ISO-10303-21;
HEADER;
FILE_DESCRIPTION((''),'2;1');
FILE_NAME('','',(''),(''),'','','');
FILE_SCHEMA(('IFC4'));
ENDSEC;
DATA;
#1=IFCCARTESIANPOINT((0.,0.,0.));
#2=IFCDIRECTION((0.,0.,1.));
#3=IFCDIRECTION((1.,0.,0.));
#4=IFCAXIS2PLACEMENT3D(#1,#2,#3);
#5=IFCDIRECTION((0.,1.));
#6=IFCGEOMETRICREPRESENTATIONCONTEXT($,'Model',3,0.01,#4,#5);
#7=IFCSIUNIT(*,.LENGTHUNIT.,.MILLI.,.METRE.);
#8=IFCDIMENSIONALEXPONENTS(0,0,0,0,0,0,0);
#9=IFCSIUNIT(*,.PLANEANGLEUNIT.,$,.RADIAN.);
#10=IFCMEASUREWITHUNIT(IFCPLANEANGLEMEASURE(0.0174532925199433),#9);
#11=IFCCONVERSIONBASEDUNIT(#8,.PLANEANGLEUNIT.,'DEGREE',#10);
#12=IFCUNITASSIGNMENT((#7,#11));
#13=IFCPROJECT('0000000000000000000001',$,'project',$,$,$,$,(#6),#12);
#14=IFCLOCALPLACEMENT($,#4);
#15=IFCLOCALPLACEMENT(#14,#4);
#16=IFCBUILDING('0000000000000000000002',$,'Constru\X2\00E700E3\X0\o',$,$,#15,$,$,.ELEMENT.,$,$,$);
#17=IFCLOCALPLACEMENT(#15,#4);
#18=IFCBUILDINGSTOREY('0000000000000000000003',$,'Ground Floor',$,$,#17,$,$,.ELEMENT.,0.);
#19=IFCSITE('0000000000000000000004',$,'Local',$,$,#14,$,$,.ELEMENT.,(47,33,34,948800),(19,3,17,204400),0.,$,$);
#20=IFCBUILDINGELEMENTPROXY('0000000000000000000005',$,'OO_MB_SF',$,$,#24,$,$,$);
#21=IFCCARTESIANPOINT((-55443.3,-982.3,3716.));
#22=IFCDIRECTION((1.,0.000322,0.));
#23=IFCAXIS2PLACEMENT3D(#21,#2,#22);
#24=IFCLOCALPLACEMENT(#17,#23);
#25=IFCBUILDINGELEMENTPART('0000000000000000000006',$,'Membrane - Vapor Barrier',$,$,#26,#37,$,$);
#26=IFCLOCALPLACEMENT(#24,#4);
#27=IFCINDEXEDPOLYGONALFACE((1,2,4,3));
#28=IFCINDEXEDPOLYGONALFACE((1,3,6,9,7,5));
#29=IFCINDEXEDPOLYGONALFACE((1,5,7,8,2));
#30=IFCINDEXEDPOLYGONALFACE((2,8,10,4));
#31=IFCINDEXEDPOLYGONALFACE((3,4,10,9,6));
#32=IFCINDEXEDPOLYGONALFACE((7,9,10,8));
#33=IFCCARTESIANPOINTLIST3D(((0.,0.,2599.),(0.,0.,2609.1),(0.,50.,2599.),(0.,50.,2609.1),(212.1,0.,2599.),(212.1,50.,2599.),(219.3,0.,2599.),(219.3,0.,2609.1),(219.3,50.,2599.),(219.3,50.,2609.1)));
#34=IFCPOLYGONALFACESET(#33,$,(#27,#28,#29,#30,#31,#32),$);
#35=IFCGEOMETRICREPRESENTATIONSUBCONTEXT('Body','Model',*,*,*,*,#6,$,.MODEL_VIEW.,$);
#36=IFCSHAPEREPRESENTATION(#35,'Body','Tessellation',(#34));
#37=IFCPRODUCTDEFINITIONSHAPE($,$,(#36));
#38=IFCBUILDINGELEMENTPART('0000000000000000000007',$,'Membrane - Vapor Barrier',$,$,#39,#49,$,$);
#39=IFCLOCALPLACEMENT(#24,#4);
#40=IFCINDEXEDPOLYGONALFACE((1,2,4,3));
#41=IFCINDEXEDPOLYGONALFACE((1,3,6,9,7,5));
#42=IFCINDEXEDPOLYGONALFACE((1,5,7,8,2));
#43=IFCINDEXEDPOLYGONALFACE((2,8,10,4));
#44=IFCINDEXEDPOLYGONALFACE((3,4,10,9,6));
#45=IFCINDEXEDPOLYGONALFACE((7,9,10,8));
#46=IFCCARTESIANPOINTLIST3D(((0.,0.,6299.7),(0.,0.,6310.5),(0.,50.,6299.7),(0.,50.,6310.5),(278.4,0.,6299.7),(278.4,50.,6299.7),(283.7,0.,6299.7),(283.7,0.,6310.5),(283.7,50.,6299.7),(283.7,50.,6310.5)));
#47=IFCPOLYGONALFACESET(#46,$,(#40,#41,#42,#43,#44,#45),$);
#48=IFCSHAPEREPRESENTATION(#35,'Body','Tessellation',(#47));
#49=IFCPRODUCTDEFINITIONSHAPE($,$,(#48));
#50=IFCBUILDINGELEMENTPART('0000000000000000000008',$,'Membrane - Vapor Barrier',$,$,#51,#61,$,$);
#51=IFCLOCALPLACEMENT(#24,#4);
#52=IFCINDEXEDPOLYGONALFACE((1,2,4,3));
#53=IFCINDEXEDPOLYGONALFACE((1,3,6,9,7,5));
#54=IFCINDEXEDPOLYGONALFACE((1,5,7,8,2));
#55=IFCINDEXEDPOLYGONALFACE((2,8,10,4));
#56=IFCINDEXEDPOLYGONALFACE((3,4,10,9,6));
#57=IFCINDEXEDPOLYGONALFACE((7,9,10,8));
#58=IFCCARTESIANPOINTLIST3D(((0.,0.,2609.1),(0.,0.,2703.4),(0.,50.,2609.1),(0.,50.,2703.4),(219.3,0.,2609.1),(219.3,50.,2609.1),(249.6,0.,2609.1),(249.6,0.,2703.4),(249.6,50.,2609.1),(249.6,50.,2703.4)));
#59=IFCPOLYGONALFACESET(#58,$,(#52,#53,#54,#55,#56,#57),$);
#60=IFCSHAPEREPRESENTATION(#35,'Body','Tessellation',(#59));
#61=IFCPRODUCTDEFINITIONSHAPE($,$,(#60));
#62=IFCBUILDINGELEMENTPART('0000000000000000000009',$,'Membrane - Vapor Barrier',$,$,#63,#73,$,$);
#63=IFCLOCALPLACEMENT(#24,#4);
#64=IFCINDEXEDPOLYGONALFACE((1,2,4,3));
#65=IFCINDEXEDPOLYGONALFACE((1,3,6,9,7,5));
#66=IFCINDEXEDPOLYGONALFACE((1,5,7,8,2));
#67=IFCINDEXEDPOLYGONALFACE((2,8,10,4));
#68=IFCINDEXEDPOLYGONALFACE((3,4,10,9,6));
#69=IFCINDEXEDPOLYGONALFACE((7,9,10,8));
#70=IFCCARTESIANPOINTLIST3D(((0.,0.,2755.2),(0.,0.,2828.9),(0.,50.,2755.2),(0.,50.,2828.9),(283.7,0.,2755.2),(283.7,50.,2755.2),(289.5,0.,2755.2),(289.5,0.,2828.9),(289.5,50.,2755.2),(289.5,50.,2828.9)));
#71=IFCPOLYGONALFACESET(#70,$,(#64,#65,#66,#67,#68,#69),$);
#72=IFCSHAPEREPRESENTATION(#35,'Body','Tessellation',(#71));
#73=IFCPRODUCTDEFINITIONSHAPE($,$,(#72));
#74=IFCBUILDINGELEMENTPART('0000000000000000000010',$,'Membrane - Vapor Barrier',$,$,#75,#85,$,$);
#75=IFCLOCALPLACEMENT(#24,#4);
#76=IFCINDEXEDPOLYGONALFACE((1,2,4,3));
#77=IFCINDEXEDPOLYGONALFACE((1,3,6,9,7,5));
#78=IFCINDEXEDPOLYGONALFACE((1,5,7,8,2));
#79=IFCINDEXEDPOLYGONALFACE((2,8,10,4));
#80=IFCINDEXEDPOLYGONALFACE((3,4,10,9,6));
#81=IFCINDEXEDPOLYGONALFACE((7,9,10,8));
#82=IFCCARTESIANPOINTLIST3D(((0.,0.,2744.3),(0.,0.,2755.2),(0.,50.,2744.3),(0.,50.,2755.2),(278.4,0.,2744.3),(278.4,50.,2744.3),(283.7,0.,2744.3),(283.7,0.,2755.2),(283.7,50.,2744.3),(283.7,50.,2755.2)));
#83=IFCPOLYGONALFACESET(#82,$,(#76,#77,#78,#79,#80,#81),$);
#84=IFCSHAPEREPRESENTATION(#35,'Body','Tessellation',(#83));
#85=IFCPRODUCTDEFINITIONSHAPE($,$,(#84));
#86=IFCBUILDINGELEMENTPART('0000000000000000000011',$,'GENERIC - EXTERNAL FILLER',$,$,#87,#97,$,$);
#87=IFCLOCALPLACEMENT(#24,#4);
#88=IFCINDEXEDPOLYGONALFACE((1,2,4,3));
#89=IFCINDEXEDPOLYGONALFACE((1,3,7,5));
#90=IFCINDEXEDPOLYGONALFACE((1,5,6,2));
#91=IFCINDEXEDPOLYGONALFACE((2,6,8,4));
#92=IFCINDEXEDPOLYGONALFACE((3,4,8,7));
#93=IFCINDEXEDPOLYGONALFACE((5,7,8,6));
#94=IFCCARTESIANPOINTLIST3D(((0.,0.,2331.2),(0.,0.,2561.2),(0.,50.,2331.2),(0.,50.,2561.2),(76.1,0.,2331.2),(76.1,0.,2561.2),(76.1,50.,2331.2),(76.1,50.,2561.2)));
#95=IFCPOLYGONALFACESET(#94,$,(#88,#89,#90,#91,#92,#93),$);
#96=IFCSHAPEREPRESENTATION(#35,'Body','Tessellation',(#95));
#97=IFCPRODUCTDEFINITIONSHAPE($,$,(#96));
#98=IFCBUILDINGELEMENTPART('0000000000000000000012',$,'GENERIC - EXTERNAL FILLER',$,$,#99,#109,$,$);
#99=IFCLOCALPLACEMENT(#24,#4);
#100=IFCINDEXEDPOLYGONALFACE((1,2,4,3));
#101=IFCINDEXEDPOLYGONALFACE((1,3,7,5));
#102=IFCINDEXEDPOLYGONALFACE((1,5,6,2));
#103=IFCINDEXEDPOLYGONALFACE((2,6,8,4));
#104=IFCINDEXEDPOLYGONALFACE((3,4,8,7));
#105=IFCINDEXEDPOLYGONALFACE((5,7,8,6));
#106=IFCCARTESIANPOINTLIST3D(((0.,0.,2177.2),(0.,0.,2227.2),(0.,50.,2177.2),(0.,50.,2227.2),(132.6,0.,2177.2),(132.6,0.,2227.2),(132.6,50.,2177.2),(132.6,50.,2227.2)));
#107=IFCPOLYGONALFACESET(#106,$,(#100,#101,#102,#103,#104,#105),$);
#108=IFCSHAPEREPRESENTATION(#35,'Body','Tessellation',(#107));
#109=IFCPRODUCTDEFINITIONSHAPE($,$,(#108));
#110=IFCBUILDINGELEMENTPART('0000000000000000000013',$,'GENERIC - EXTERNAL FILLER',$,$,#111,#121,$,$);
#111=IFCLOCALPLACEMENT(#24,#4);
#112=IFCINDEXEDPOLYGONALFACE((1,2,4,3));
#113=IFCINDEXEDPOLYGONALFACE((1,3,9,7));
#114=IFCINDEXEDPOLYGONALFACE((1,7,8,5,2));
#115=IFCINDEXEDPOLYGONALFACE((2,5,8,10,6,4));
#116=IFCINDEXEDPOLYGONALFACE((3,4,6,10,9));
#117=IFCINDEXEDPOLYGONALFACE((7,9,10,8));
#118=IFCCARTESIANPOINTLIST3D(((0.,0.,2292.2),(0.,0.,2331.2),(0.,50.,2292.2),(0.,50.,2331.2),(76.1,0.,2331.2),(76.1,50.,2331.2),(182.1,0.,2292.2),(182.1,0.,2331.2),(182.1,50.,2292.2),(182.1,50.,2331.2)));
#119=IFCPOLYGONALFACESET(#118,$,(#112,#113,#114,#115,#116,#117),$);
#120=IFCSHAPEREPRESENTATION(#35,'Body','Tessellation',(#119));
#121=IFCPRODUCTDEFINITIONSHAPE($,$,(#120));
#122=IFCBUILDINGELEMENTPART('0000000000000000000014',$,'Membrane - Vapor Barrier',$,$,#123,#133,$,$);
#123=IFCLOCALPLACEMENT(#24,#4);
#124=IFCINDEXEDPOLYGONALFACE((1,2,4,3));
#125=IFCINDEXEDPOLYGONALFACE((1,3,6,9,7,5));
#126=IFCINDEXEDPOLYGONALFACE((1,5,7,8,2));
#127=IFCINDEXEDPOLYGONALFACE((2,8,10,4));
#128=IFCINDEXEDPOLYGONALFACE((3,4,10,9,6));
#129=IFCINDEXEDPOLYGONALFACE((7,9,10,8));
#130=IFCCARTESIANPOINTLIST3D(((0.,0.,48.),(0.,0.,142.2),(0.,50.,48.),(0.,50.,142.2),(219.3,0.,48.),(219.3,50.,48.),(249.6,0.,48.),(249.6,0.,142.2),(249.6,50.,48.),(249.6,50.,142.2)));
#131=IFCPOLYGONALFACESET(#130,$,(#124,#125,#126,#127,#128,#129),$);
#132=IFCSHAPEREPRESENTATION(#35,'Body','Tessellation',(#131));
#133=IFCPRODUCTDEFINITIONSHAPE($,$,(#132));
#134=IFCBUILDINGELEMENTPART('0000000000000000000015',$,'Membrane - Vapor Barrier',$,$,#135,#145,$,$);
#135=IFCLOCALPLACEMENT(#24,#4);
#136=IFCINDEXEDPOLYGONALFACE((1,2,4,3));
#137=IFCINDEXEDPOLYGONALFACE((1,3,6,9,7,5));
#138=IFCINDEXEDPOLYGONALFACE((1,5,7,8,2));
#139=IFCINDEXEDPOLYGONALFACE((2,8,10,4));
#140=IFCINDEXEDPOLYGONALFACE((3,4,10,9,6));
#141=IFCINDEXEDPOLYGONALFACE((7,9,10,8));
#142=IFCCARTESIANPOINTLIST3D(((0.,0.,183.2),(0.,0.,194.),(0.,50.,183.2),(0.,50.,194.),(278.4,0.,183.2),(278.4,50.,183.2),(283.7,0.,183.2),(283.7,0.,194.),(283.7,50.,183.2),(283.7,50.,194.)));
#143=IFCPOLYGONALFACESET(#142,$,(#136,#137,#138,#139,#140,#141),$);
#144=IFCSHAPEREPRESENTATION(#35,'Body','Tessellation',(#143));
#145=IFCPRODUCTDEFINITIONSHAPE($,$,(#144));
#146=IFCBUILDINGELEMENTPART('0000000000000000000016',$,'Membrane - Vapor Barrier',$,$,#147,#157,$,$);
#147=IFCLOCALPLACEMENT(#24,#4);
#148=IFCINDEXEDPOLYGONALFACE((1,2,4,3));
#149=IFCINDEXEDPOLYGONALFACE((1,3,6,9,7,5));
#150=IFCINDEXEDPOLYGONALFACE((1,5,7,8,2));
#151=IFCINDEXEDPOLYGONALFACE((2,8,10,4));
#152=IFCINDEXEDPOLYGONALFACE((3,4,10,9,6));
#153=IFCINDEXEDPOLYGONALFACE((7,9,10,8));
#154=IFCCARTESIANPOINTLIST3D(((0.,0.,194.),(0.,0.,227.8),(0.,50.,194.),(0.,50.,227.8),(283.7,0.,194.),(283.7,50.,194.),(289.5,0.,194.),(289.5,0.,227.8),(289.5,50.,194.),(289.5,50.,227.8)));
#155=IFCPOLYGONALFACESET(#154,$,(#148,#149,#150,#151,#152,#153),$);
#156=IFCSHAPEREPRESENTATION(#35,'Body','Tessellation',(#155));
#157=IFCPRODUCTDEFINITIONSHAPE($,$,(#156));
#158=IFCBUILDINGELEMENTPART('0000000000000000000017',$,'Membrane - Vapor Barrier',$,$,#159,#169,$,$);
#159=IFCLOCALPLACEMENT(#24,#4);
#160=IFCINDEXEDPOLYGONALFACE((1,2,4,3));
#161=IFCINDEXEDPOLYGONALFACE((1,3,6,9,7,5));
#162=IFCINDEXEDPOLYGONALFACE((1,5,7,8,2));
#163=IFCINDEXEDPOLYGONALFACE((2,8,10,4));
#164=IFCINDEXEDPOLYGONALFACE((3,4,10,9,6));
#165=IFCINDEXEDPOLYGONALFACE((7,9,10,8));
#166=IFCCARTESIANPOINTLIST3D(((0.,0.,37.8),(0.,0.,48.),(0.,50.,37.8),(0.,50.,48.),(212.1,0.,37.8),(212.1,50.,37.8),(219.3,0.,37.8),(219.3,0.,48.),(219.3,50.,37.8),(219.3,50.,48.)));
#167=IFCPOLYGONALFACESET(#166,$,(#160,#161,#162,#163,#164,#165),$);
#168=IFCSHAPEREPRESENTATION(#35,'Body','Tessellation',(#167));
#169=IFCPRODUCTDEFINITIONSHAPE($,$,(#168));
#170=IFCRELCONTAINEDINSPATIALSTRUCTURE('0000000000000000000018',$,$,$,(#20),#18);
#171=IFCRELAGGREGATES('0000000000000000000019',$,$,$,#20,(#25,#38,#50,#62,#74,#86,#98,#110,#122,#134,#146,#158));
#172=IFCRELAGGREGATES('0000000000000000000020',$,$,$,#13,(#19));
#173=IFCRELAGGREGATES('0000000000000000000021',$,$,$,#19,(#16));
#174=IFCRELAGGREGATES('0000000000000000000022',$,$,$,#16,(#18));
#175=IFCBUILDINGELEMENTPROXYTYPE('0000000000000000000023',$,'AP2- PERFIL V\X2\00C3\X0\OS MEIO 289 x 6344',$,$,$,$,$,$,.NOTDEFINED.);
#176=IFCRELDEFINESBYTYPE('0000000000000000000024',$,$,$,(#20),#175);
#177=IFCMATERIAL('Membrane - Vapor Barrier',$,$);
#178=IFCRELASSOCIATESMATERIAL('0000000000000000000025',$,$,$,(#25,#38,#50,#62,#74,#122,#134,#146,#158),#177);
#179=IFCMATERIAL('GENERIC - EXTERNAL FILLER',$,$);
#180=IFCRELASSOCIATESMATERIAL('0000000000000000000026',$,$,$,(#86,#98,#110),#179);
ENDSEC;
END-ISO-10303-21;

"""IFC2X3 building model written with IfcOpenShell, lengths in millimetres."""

from ifc_helpers import new_model, entity, si_unit, converted_unit, direction, frame, origin_with_axes, place, context, subcontext, project, spatial, polyline, outline, extrude, material, type_object, element, aggregate, save


model = new_model("IFC2X3")

# Units and contexts
model_context = context("Model", 3, precision=0.01, world=origin_with_axes(), true_north=direction((0.0, 1.0)))
body_context = subcontext(model_context, "Body", "Model", "MODEL_VIEW")
ifc_project = project(units=[si_unit("LENGTHUNIT", "METRE", prefix="MILLI"), converted_unit("PLANEANGLEUNIT", "DEGREE", entity("IfcPlaneAngleMeasure", 0.0174532925199433), si_unit("PLANEANGLEUNIT", "RADIAN"), dimensions=[0, 0, 0, 0, 0, 0, 0])], contexts=[model_context])

# Site, building, storey
site_placement = place(None, origin_with_axes())
site = spatial("IfcSite", under=ifc_project, at=site_placement, Name="Local", CompositionType="ELEMENT", RefLatitude=(47, 33, 34, 948800), RefLongitude=(19, 3, 17, 204400), RefElevation=0.0)
building_placement = place(site_placement, origin_with_axes())
building = spatial("IfcBuilding", under=site, at=building_placement, Name="Construção", CompositionType="ELEMENT")
storey_placement = place(building_placement, origin_with_axes())
storey = spatial("IfcBuildingStorey", under=building, at=storey_placement, Name="Ground Floor", CompositionType="ELEMENT", Elevation=0.0)

# Building element proxy, building element parts
building_element_proxy_type = type_object("IfcBuildingElementProxyType", Name="AP2- PERFIL VÃOS MEIO 289 x 6344", PredefinedType="NOTDEFINED")
ifc_material_1 = material(Name="Membrane - Vapor Barrier")
ifc_material_2 = material(Name="GENERIC - EXTERNAL FILLER")
proxy_1_placement = place(storey_placement, frame((-55443.3, -982.3, 3716.0), z_axis=(0.0, 0.0, 1.0), x_axis=(1.0, 0.000322, 0.0)))
proxy_1 = element("IfcBuildingElementProxy", 1, at=proxy_1_placement, inside=storey, type_object=building_element_proxy_type, Name="OO_MB_SF")
building_element_part_1_placement = place(proxy_1_placement, origin_with_axes())
building_element_part_1 = element("IfcBuildingElementPart", 2, at=building_element_part_1_placement, material=ifc_material_1, Name="Membrane - Vapor Barrier", context=body_context, shape_type="SweptSolid", body=[
    extrude(outline(polyline([(0.0, 2599.0), (212.1, 2599.0), (219.3, 2599.0), (219.3, 2609.1), (0.0, 2609.1), (0.0, 2599.0)])), frame((0.0, 50.0, 0.0), z_axis=(0.0, -1.0, 0.0), x_axis=(1.0, 0.0, 0.0)), (0.0, 0.0, 1.0), 50.0),
])
building_element_part_2_placement = place(proxy_1_placement, origin_with_axes())
building_element_part_2 = element("IfcBuildingElementPart", 3, at=building_element_part_2_placement, material=ifc_material_1, Name="Membrane - Vapor Barrier", context=body_context, shape_type="SweptSolid", body=[
    extrude(outline(polyline([(0.0, 6299.7), (278.4, 6299.7), (283.7, 6299.7), (283.7, 6310.5), (0.0, 6310.5), (0.0, 6299.7)])), frame((0.0, 50.0, 0.0), z_axis=(0.0, -1.0, 0.0), x_axis=(1.0, 0.0, 0.0)), (0.0, 0.0, 1.0), 50.0),
])
building_element_part_3_placement = place(proxy_1_placement, origin_with_axes())
building_element_part_3 = element("IfcBuildingElementPart", 4, at=building_element_part_3_placement, material=ifc_material_1, Name="Membrane - Vapor Barrier", context=body_context, shape_type="SweptSolid", body=[
    extrude(outline(polyline([(249.6, 2703.4), (0.0, 2703.4), (0.0, 2609.1), (219.3, 2609.1), (249.6, 2609.1), (249.6, 2703.4)])), frame((0.0, 50.0, 0.0), z_axis=(0.0, -1.0, 0.0), x_axis=(1.0, 0.0, 0.0)), (0.0, 0.0, 1.0), 50.0),
])
building_element_part_4_placement = place(proxy_1_placement, origin_with_axes())
building_element_part_4 = element("IfcBuildingElementPart", 5, at=building_element_part_4_placement, material=ifc_material_1, Name="Membrane - Vapor Barrier", context=body_context, shape_type="SweptSolid", body=[
    extrude(outline(polyline([(0.0, 2755.2), (283.7, 2755.2), (289.5, 2755.2), (289.5, 2828.9), (0.0, 2828.9), (0.0, 2755.2)])), frame((0.0, 50.0, 0.0), z_axis=(0.0, -1.0, 0.0), x_axis=(1.0, 0.0, 0.0)), (0.0, 0.0, 1.0), 50.0),
])
building_element_part_5_placement = place(proxy_1_placement, origin_with_axes())
building_element_part_5 = element("IfcBuildingElementPart", 6, at=building_element_part_5_placement, material=ifc_material_1, Name="Membrane - Vapor Barrier", context=body_context, shape_type="SweptSolid", body=[
    extrude(outline(polyline([(0.0, 2744.3), (278.4, 2744.3), (283.7, 2744.3), (283.7, 2755.2), (0.0, 2755.2), (0.0, 2744.3)])), frame((0.0, 50.0, 0.0), z_axis=(0.0, -1.0, 0.0), x_axis=(1.0, 0.0, 0.0)), (0.0, 0.0, 1.0), 50.0),
])
building_element_part_6_placement = place(proxy_1_placement, origin_with_axes())
building_element_part_6 = element("IfcBuildingElementPart", 7, at=building_element_part_6_placement, material=ifc_material_2, Name="GENERIC - EXTERNAL FILLER", context=body_context, shape_type="SweptSolid", body=[
    extrude(outline(polyline([(76.1, 2561.2), (0.0, 2561.2), (0.0, 2331.2), (76.1, 2331.2), (76.1, 2561.2)])), frame((0.0, 50.0, 0.0), z_axis=(0.0, -1.0, 0.0), x_axis=(1.0, 0.0, 0.0)), (0.0, 0.0, 1.0), 50.0),
])
building_element_part_7_placement = place(proxy_1_placement, origin_with_axes())
building_element_part_7 = element("IfcBuildingElementPart", 8, at=building_element_part_7_placement, material=ifc_material_2, Name="GENERIC - EXTERNAL FILLER", context=body_context, shape_type="SweptSolid", body=[
    extrude(outline(polyline([(0.0, 2227.2), (0.0, 2177.2), (132.6, 2177.2), (132.6, 2227.2), (0.0, 2227.2)])), frame((0.0, 50.0, 0.0), z_axis=(0.0, -1.0, 0.0), x_axis=(1.0, 0.0, 0.0)), (0.0, 0.0, 1.0), 50.0),
])
building_element_part_8_placement = place(proxy_1_placement, origin_with_axes())
building_element_part_8 = element("IfcBuildingElementPart", 9, at=building_element_part_8_placement, material=ifc_material_2, Name="GENERIC - EXTERNAL FILLER", context=body_context, shape_type="SweptSolid", body=[
    extrude(outline(polyline([(0.0, 2331.2), (0.0, 2292.2), (182.1, 2292.2), (182.1, 2331.2), (76.1, 2331.2), (0.0, 2331.2)])), frame((0.0, 50.0, 0.0), z_axis=(0.0, -1.0, 0.0), x_axis=(1.0, 0.0, 0.0)), (0.0, 0.0, 1.0), 50.0),
])
building_element_part_9_placement = place(proxy_1_placement, origin_with_axes())
building_element_part_9 = element("IfcBuildingElementPart", 10, at=building_element_part_9_placement, material=ifc_material_1, Name="Membrane - Vapor Barrier", context=body_context, shape_type="SweptSolid", body=[
    extrude(outline(polyline([(249.6, 142.2), (0.0, 142.2), (0.0, 48.0), (219.3, 48.0), (249.6, 48.0), (249.6, 142.2)])), frame((0.0, 50.0, 0.0), z_axis=(0.0, -1.0, 0.0), x_axis=(1.0, 0.0, 0.0)), (0.0, 0.0, 1.0), 50.0),
])
building_element_part_10_placement = place(proxy_1_placement, origin_with_axes())
building_element_part_10 = element("IfcBuildingElementPart", 11, at=building_element_part_10_placement, material=ifc_material_1, Name="Membrane - Vapor Barrier", context=body_context, shape_type="SweptSolid", body=[
    extrude(outline(polyline([(0.0, 183.2), (278.4, 183.2), (283.7, 183.2), (283.7, 194.0), (0.0, 194.0), (0.0, 183.2)])), frame((0.0, 50.0, 0.0), z_axis=(0.0, -1.0, 0.0), x_axis=(1.0, 0.0, 0.0)), (0.0, 0.0, 1.0), 50.0),
])
building_element_part_11_placement = place(proxy_1_placement, origin_with_axes())
building_element_part_11 = element("IfcBuildingElementPart", 12, at=building_element_part_11_placement, material=ifc_material_1, Name="Membrane - Vapor Barrier", context=body_context, shape_type="SweptSolid", body=[
    extrude(outline(polyline([(0.0, 194.0), (283.7, 194.0), (289.5, 194.0), (289.5, 227.8), (0.0, 227.8), (0.0, 194.0)])), frame((0.0, 50.0, 0.0), z_axis=(0.0, -1.0, 0.0), x_axis=(1.0, 0.0, 0.0)), (0.0, 0.0, 1.0), 50.0),
])
building_element_part_12_placement = place(proxy_1_placement, origin_with_axes())
building_element_part_12 = element("IfcBuildingElementPart", 13, at=building_element_part_12_placement, material=ifc_material_1, Name="Membrane - Vapor Barrier", context=body_context, shape_type="SweptSolid", body=[
    extrude(outline(polyline([(0.0, 37.8), (212.1, 37.8), (219.3, 37.8), (219.3, 48.0), (0.0, 48.0), (0.0, 37.8)])), frame((0.0, 50.0, 0.0), z_axis=(0.0, -1.0, 0.0), x_axis=(1.0, 0.0, 0.0)), (0.0, 0.0, 1.0), 50.0),
])
aggregate(proxy_1, [building_element_part_1, building_element_part_2, building_element_part_3, building_element_part_4, building_element_part_5, building_element_part_6, building_element_part_7, building_element_part_8, building_element_part_9, building_element_part_10, building_element_part_11, building_element_part_12])

save(model, "model.ifc")
